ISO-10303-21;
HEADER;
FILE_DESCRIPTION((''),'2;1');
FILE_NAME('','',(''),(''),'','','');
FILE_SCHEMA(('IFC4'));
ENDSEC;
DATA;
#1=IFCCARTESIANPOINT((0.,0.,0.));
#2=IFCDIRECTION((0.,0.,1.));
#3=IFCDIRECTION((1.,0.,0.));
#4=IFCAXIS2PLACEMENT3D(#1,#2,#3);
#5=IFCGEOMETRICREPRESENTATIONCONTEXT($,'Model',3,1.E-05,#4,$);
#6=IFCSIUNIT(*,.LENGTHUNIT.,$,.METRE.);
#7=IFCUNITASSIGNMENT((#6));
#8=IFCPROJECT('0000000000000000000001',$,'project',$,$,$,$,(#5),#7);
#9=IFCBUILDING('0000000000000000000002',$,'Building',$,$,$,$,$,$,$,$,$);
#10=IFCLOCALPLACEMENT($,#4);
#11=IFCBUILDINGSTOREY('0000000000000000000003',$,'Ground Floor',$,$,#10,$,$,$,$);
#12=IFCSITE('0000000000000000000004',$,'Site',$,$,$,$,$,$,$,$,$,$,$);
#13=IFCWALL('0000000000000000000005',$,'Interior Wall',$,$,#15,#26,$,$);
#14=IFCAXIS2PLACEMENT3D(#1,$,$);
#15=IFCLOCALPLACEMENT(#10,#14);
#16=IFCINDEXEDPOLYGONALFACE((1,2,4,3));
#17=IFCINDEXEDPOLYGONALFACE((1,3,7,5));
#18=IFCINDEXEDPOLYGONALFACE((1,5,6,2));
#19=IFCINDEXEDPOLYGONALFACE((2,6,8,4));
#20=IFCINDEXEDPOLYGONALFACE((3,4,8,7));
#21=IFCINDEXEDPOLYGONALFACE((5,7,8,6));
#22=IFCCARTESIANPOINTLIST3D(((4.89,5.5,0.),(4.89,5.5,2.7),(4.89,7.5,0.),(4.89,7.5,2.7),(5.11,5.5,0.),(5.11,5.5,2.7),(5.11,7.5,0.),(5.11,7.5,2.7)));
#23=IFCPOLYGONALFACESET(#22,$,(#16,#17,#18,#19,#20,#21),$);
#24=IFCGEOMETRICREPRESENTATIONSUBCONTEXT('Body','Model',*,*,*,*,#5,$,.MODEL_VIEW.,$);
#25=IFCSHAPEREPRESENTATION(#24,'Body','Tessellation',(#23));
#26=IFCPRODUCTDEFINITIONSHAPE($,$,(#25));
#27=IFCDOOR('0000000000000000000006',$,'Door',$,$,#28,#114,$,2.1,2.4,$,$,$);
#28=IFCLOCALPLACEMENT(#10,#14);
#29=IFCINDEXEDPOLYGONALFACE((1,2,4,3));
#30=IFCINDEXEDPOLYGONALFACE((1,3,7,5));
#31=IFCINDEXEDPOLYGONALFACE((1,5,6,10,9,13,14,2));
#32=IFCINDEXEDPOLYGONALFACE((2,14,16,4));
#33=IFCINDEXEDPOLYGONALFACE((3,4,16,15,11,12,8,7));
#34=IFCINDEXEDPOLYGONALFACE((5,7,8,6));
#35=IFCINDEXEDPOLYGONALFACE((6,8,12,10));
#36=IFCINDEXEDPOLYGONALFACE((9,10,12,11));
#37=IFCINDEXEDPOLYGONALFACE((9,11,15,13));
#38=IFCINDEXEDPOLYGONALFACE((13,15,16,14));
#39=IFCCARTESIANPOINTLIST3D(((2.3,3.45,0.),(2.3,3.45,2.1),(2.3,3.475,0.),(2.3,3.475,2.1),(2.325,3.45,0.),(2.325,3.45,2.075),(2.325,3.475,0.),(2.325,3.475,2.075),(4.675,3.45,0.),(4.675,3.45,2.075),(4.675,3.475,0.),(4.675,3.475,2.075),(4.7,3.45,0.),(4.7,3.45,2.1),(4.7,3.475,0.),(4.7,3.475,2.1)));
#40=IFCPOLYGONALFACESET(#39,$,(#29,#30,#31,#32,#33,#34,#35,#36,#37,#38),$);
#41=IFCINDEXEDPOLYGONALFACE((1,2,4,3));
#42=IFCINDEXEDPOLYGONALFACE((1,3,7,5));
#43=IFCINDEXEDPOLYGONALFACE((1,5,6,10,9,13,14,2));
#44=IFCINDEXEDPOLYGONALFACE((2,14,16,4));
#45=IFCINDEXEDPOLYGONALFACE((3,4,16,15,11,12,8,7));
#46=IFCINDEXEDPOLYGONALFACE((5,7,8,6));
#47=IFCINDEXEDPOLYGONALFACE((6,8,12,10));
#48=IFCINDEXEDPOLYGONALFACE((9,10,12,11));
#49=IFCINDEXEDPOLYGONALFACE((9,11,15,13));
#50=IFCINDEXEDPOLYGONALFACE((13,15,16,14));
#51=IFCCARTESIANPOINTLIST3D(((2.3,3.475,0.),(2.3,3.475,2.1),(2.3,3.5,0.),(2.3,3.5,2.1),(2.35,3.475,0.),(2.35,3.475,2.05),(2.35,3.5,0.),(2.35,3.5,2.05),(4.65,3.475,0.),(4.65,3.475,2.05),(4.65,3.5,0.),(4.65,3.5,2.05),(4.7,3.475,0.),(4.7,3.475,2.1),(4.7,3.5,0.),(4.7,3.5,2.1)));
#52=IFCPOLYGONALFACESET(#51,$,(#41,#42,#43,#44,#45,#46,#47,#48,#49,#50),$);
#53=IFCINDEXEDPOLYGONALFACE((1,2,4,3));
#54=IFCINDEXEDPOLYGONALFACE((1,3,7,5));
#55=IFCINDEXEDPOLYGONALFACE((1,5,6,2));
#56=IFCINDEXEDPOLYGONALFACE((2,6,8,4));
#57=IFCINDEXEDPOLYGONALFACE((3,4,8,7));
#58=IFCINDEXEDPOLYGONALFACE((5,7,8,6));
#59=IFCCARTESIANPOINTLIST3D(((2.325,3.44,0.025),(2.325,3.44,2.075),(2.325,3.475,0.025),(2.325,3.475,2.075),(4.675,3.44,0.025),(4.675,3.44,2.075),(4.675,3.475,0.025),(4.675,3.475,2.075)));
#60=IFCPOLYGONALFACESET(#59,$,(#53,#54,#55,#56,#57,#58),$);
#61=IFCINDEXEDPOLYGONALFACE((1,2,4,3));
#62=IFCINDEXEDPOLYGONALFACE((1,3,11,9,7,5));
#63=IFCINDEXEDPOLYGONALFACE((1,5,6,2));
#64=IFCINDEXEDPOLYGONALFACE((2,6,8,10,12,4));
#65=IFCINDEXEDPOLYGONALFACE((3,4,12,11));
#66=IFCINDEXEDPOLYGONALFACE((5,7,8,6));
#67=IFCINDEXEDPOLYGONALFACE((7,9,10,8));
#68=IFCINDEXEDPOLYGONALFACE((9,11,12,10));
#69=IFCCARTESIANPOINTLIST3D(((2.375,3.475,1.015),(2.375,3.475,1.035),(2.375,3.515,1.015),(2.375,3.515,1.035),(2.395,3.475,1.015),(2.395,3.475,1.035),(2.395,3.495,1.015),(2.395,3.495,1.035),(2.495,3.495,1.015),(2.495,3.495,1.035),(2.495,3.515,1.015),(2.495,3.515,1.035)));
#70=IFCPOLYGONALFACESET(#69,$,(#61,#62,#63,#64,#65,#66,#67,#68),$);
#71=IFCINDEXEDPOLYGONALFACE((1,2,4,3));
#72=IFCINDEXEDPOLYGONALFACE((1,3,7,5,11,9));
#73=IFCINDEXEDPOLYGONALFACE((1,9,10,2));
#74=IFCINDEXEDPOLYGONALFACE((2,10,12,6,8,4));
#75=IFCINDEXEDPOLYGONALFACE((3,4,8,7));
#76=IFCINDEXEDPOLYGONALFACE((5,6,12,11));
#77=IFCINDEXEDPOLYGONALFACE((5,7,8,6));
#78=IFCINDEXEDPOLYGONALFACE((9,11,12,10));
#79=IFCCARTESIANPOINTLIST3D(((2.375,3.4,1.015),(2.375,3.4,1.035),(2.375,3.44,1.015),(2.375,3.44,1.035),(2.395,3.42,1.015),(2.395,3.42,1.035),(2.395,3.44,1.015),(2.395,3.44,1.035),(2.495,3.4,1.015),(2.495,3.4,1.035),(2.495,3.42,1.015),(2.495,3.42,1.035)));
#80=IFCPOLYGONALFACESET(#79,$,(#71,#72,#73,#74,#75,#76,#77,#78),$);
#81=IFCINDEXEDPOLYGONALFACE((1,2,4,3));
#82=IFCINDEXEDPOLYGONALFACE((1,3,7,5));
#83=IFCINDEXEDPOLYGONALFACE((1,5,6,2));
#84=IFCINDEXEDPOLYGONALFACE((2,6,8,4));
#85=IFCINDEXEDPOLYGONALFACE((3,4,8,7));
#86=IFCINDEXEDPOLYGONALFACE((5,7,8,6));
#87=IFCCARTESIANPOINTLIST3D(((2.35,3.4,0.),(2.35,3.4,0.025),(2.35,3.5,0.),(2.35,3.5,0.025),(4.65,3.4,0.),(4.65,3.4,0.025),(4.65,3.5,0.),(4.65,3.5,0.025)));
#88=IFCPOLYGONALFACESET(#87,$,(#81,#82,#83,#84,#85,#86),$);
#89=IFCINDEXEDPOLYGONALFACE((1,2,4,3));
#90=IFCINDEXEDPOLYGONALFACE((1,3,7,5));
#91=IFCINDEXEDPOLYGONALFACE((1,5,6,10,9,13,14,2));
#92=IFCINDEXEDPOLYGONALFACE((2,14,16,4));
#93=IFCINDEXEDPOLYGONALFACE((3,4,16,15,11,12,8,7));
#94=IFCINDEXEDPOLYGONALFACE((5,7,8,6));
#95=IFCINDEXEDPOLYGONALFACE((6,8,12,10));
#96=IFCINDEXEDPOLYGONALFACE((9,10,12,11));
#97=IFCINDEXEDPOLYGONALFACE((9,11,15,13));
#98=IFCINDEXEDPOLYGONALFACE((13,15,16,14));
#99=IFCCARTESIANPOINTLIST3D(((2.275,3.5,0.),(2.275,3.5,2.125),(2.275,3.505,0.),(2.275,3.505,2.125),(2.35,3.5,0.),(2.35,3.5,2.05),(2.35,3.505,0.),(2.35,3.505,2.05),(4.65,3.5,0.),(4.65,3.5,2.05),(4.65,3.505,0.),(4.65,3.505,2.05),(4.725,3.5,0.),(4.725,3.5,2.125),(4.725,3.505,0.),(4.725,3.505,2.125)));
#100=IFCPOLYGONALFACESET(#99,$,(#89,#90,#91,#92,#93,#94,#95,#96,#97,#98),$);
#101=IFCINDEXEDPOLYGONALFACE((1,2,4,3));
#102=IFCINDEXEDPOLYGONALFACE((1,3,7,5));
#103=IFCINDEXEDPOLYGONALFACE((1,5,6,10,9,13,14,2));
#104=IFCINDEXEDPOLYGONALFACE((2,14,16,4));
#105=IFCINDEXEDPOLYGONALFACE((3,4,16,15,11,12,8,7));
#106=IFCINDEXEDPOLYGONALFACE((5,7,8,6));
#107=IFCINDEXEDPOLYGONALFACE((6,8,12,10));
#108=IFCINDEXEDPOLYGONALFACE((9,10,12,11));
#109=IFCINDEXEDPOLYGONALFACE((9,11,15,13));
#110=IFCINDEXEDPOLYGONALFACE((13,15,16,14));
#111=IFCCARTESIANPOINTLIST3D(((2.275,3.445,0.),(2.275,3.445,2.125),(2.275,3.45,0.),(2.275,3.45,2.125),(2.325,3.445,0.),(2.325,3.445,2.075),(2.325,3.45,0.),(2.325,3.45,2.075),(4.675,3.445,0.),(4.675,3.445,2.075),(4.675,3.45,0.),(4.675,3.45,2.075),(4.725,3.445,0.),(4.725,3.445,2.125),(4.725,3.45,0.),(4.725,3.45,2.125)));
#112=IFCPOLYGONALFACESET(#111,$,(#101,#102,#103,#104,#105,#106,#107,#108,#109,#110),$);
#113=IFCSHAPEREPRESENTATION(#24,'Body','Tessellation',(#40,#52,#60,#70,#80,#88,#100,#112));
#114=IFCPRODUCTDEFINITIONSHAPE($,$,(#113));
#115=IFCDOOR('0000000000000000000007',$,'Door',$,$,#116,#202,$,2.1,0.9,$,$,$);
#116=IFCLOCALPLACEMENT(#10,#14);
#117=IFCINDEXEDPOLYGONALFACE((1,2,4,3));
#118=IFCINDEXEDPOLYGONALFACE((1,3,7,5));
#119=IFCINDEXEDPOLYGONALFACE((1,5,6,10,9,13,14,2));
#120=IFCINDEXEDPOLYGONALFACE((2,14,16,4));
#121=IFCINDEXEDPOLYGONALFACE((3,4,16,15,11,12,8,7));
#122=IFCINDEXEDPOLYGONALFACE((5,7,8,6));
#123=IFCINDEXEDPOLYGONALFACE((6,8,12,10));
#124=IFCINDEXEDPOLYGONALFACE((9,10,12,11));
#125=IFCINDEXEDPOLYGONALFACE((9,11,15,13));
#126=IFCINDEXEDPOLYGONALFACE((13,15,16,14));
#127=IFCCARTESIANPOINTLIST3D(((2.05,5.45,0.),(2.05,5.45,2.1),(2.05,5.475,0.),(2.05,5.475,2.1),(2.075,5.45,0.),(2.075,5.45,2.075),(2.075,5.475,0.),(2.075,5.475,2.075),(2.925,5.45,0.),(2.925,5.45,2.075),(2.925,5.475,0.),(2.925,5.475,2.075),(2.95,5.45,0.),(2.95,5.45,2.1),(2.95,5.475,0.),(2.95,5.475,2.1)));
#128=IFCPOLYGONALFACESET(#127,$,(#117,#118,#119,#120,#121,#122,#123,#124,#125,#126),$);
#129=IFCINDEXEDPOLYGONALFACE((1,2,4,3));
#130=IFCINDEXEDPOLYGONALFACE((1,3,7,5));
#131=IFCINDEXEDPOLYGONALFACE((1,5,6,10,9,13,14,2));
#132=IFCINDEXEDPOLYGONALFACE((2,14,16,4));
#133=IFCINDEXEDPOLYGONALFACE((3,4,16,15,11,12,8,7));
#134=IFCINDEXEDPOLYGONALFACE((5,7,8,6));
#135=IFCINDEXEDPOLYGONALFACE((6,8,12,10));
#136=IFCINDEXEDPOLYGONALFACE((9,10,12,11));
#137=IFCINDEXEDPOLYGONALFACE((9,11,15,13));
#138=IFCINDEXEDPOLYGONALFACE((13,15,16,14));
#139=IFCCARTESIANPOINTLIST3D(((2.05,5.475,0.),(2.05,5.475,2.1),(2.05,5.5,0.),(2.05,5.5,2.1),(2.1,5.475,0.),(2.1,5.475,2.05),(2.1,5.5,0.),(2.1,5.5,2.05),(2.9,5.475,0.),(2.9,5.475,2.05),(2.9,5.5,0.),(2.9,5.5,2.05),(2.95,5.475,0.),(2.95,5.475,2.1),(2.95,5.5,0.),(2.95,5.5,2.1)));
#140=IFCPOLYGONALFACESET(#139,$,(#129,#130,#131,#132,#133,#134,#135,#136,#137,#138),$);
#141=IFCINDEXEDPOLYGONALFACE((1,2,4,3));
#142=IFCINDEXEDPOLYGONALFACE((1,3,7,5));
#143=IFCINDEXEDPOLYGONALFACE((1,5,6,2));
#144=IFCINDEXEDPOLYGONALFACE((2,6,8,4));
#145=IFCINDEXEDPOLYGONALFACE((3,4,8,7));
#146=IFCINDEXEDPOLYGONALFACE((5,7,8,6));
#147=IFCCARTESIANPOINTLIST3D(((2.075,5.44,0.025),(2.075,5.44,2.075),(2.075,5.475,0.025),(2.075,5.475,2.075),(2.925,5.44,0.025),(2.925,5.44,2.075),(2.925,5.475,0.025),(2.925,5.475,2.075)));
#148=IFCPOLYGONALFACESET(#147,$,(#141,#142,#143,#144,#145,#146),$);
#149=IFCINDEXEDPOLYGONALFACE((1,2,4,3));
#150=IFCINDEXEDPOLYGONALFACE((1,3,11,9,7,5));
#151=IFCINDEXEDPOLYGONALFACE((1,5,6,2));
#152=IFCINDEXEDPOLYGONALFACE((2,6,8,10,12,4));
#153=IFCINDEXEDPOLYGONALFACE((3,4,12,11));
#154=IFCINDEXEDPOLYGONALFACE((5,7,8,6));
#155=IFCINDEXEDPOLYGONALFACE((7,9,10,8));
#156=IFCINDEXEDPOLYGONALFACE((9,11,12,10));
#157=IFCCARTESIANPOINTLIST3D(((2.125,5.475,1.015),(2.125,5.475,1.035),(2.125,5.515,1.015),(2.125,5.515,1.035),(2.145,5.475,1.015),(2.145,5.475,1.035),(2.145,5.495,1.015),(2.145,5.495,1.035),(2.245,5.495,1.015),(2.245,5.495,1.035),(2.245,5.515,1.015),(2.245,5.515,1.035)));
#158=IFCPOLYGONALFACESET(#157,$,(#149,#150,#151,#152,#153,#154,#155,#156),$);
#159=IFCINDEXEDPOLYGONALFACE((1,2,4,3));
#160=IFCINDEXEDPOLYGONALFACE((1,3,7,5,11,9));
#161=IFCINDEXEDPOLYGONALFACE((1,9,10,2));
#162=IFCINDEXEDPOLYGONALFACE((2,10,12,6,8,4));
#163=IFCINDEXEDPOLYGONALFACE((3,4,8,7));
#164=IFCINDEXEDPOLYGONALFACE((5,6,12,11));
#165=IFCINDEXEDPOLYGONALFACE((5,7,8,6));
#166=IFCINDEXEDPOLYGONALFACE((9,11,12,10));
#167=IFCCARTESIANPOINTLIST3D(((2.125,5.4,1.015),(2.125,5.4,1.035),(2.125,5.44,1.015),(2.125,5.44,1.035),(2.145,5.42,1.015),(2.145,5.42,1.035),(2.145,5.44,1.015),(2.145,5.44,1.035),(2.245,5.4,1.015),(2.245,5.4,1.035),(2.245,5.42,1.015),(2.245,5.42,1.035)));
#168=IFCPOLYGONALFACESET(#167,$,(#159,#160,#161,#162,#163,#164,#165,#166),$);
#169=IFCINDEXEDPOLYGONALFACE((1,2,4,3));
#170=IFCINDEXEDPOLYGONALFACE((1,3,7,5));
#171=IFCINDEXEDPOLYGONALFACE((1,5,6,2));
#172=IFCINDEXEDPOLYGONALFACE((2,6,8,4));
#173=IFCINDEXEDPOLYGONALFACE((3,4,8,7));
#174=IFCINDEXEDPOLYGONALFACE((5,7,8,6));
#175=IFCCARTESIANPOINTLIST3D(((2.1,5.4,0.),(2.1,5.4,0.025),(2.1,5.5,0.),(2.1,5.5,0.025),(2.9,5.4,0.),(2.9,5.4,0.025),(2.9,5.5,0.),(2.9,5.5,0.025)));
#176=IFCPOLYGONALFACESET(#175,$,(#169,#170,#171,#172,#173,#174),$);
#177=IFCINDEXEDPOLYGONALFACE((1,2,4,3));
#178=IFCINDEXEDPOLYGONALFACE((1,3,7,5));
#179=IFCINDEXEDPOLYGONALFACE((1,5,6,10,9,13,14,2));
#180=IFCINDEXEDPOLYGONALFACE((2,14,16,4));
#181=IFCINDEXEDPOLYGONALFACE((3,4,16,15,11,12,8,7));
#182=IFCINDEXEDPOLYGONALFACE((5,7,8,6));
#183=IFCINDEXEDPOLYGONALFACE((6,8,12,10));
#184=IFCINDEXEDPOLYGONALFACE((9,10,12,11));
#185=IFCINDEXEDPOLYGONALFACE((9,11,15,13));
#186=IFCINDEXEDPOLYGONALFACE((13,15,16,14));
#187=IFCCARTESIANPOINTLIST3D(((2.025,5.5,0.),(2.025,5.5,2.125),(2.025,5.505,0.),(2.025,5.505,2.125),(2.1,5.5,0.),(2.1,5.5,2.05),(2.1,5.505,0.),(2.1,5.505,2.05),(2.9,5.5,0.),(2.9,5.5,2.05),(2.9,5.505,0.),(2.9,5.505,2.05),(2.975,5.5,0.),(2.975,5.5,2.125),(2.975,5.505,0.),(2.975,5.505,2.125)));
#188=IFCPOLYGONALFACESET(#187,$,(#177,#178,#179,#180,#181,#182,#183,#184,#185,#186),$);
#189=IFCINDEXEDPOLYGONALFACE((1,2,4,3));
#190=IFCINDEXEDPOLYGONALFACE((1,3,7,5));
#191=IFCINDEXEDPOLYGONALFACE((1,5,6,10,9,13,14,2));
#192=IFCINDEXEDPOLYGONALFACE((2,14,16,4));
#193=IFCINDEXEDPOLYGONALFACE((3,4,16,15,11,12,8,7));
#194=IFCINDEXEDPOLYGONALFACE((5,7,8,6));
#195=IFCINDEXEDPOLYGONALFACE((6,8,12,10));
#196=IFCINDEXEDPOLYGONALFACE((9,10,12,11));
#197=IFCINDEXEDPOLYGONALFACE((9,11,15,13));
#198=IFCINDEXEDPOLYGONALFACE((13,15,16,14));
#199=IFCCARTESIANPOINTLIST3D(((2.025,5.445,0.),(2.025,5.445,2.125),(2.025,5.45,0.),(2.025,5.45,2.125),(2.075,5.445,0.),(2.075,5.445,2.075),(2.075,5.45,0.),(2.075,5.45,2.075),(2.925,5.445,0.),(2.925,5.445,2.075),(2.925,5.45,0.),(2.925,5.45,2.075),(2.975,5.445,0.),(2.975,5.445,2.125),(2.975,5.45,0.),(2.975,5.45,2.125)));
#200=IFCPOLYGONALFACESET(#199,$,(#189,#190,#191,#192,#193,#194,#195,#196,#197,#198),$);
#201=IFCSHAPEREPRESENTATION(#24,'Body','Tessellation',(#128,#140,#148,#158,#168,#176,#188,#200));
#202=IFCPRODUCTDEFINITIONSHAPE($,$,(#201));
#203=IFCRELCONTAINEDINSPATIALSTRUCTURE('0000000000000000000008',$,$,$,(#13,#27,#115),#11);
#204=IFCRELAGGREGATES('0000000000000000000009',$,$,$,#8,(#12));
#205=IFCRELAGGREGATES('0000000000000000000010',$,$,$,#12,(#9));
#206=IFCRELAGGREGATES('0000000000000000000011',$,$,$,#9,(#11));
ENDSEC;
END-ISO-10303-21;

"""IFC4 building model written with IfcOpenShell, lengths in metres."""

from ifc_helpers import new_model, si_unit, frame, origin_with_axes, place, context, subcontext, project, spatial, line, indexed_curve, outline, extrude, element, save


model = new_model("IFC4")

# Units and contexts
model_context = context("Model", 3, precision=1e-05, world=origin_with_axes())
body_context = subcontext(model_context, "Body", "Model", "MODEL_VIEW")
ifc_project = project(units=[si_unit("LENGTHUNIT", "METRE")], contexts=[model_context])

# Site, building, storey
site = spatial("IfcSite", under=ifc_project, Name="Site")
building = spatial("IfcBuilding", under=site, Name="Building")
storey_placement = place(None, origin_with_axes())
storey = spatial("IfcBuildingStorey", under=building, at=storey_placement, Name="Ground Floor")

# Wall
for number, where, z_axis, x_axis, name in (
    (1, (5.0, 5.5, 0.0), (0.0, 0.0, 1.0), (0.0, 1.0, 0.0), "Interior Wall"),
):
    element("IfcWall", number, at=place(storey_placement, frame(where, z_axis=z_axis, x_axis=x_axis)), inside=storey, Name=name, context=body_context, shape_type="SweptSolid", body=[
        extrude(outline(indexed_curve([(0.0, 0.0), (0.0, 0.22), (2.0, 0.22), (2.0, 0.0), (0.0, 0.0)], self_intersect=False)), frame((0.0, -0.11, 0.0), z_axis=(0.0, 0.0, 1.0), x_axis=(1.0, 0.0, 0.0)), (0.0, 0.0, 1.0), 2.7),
    ])

# Doors
door_1_placement = place(storey_placement, frame((4.7, 3.5, 0.0), z_axis=(0.0, 0.0, 1.0), x_axis=(-1.0, 0.0, 0.0)))
element("IfcDoor", 2, at=door_1_placement, inside=storey, Name="Door", OverallHeight=2.1, OverallWidth=2.4, context=body_context, shape_type="SweptSolid", body=[
    extrude(outline(indexed_curve([(0.0, 0.0), (0.0, 2.1), (2.4, 2.1), (2.4, 0.0), (2.375, 0.0), (2.375, 2.075), (0.025, 2.075), (0.025, 0.0)], segments=[line(1, 2, 3, 4, 5, 6, 7, 8, 1)])), frame((0.0, 0.025, 0.0), z_axis=(0.0, -1.0, 0.0), x_axis=(1.0, 0.0, 0.0)), (0.0, 0.0, -1.0), 0.025),
    extrude(outline(indexed_curve([(0.0, 0.0), (0.0, 2.1), (2.4, 2.1), (2.4, 0.0), (2.35, 0.0), (2.35, 2.05), (0.05, 2.05), (0.05, 0.0)], segments=[line(1, 2, 3, 4, 5, 6, 7, 8, 1)])), frame((0.0, 0.0, 0.0), z_axis=(0.0, -1.0, 0.0), x_axis=(1.0, 0.0, 0.0)), (0.0, 0.0, -1.0), 0.025),
    extrude(outline(indexed_curve([(0.0, 0.0), (2.35, 0.0), (2.35, 0.035), (0.0, 0.035)], segments=[line(1, 2, 3, 4, 1)])), frame((0.025, 0.025, 0.025), z_axis=(0.0, 0.0, 1.0), x_axis=(1.0, 0.0, 0.0)), (0.0, 0.0, 1.0), 2.05),
    extrude(outline(indexed_curve([(0.0, 0.0), (0.0, -0.04), (-0.12, -0.04), (-0.12, -0.02), (-0.02, -0.02), (-0.02, 0.0)], segments=[line(1, 2, 3, 4, 5, 6, 1)])), frame((2.325, 0.025, 1.015), z_axis=(0.0, 0.0, 1.0), x_axis=(1.0, 0.0, 0.0)), (0.0, 0.0, 1.0), 0.02),
    extrude(outline(indexed_curve([(0.0, 0.0), (0.0, 0.04), (-0.12, 0.04), (-0.12, 0.02), (-0.02, 0.02), (-0.02, 0.0)], segments=[line(1, 2, 3, 4, 5, 6, 1)])), frame((2.325, 0.06, 1.015), z_axis=(0.0, 0.0, 1.0), x_axis=(1.0, 0.0, 0.0)), (0.0, 0.0, 1.0), 0.02),
    extrude(outline(indexed_curve([(0.0, 0.0), (2.3, 0.0), (2.3, 0.1), (0.0, 0.1)], segments=[line(1, 2, 3, 4, 1)])), frame((0.05, 0.0, 0.0), z_axis=(0.0, 0.0, 1.0), x_axis=(1.0, 0.0, 0.0)), (0.0, 0.0, 1.0), 0.025),
    extrude(outline(indexed_curve([(0.0, 0.0), (0.0, 2.125), (2.45, 2.125), (2.45, 0.0), (2.375, 0.0), (2.375, 2.05), (0.075, 2.05), (0.075, 0.0)], segments=[line(1, 2, 3, 4, 5, 6, 7, 8, 1)])), frame((-0.025, -0.005, 0.0), z_axis=(0.0, -1.0, 0.0), x_axis=(1.0, 0.0, 0.0)), (0.0, 0.0, -1.0), 0.005),
    extrude(outline(indexed_curve([(0.0, 0.0), (0.0, 2.125), (2.45, 2.125), (2.45, 0.0), (2.4, 0.0), (2.4, 2.075), (0.05, 2.075), (0.05, 0.0)], segments=[line(1, 2, 3, 4, 5, 6, 7, 8, 1)])), frame((-0.025, 0.05, 0.0), z_axis=(0.0, -1.0, 0.0), x_axis=(1.0, 0.0, 0.0)), (0.0, 0.0, -1.0), 0.005),
])
door_2_placement = place(storey_placement, frame((2.95, 5.5, 0.0), z_axis=(0.0, 0.0, 1.0), x_axis=(-1.0, 0.0, 0.0)))
element("IfcDoor", 3, at=door_2_placement, inside=storey, Name="Door", OverallHeight=2.1, OverallWidth=0.9, context=body_context, shape_type="SweptSolid", body=[
    extrude(outline(indexed_curve([(0.0, 0.0), (0.0, 2.1), (0.9, 2.1), (0.9, 0.0), (0.875, 0.0), (0.875, 2.075), (0.025, 2.075), (0.025, 0.0)], segments=[line(1, 2, 3, 4, 5, 6, 7, 8, 1)])), frame((0.0, 0.025, 0.0), z_axis=(0.0, -1.0, 0.0), x_axis=(1.0, 0.0, 0.0)), (0.0, 0.0, -1.0), 0.025),
    extrude(outline(indexed_curve([(0.0, 0.0), (0.0, 2.1), (0.9, 2.1), (0.9, 0.0), (0.85, 0.0), (0.85, 2.05), (0.05, 2.05), (0.05, 0.0)], segments=[line(1, 2, 3, 4, 5, 6, 7, 8, 1)])), frame((0.0, 0.0, 0.0), z_axis=(0.0, -1.0, 0.0), x_axis=(1.0, 0.0, 0.0)), (0.0, 0.0, -1.0), 0.025),
    extrude(outline(indexed_curve([(0.0, 0.0), (0.85, 0.0), (0.85, 0.035), (0.0, 0.035)], segments=[line(1, 2, 3, 4, 1)])), frame((0.025, 0.025, 0.025), z_axis=(0.0, 0.0, 1.0), x_axis=(1.0, 0.0, 0.0)), (0.0, 0.0, 1.0), 2.05),
    extrude(outline(indexed_curve([(0.0, 0.0), (0.0, -0.04), (-0.12, -0.04), (-0.12, -0.02), (-0.02, -0.02), (-0.02, 0.0)], segments=[line(1, 2, 3, 4, 5, 6, 1)])), frame((0.825, 0.025, 1.015), z_axis=(0.0, 0.0, 1.0), x_axis=(1.0, 0.0, 0.0)), (0.0, 0.0, 1.0), 0.02),
    extrude(outline(indexed_curve([(0.0, 0.0), (0.0, 0.04), (-0.12, 0.04), (-0.12, 0.02), (-0.02, 0.02), (-0.02, 0.0)], segments=[line(1, 2, 3, 4, 5, 6, 1)])), frame((0.825, 0.06, 1.015), z_axis=(0.0, 0.0, 1.0), x_axis=(1.0, 0.0, 0.0)), (0.0, 0.0, 1.0), 0.02),
    extrude(outline(indexed_curve([(0.0, 0.0), (0.8, 0.0), (0.8, 0.1), (0.0, 0.1)], segments=[line(1, 2, 3, 4, 1)])), frame((0.05, 0.0, 0.0), z_axis=(0.0, 0.0, 1.0), x_axis=(1.0, 0.0, 0.0)), (0.0, 0.0, 1.0), 0.025),
    extrude(outline(indexed_curve([(0.0, 0.0), (0.0, 2.125), (0.95, 2.125), (0.95, 0.0), (0.875, 0.0), (0.875, 2.05), (0.075, 2.05), (0.075, 0.0)], segments=[line(1, 2, 3, 4, 5, 6, 7, 8, 1)])), frame((-0.025, -0.005, 0.0), z_axis=(0.0, -1.0, 0.0), x_axis=(1.0, 0.0, 0.0)), (0.0, 0.0, -1.0), 0.005),
    extrude(outline(indexed_curve([(0.0, 0.0), (0.0, 2.125), (0.95, 2.125), (0.95, 0.0), (0.9, 0.0), (0.9, 2.075), (0.05, 2.075), (0.05, 0.0)], segments=[line(1, 2, 3, 4, 5, 6, 7, 8, 1)])), frame((-0.025, 0.05, 0.0), z_axis=(0.0, -1.0, 0.0), x_axis=(1.0, 0.0, 0.0)), (0.0, 0.0, -1.0), 0.005),
])

save(model, "model.ifc")
